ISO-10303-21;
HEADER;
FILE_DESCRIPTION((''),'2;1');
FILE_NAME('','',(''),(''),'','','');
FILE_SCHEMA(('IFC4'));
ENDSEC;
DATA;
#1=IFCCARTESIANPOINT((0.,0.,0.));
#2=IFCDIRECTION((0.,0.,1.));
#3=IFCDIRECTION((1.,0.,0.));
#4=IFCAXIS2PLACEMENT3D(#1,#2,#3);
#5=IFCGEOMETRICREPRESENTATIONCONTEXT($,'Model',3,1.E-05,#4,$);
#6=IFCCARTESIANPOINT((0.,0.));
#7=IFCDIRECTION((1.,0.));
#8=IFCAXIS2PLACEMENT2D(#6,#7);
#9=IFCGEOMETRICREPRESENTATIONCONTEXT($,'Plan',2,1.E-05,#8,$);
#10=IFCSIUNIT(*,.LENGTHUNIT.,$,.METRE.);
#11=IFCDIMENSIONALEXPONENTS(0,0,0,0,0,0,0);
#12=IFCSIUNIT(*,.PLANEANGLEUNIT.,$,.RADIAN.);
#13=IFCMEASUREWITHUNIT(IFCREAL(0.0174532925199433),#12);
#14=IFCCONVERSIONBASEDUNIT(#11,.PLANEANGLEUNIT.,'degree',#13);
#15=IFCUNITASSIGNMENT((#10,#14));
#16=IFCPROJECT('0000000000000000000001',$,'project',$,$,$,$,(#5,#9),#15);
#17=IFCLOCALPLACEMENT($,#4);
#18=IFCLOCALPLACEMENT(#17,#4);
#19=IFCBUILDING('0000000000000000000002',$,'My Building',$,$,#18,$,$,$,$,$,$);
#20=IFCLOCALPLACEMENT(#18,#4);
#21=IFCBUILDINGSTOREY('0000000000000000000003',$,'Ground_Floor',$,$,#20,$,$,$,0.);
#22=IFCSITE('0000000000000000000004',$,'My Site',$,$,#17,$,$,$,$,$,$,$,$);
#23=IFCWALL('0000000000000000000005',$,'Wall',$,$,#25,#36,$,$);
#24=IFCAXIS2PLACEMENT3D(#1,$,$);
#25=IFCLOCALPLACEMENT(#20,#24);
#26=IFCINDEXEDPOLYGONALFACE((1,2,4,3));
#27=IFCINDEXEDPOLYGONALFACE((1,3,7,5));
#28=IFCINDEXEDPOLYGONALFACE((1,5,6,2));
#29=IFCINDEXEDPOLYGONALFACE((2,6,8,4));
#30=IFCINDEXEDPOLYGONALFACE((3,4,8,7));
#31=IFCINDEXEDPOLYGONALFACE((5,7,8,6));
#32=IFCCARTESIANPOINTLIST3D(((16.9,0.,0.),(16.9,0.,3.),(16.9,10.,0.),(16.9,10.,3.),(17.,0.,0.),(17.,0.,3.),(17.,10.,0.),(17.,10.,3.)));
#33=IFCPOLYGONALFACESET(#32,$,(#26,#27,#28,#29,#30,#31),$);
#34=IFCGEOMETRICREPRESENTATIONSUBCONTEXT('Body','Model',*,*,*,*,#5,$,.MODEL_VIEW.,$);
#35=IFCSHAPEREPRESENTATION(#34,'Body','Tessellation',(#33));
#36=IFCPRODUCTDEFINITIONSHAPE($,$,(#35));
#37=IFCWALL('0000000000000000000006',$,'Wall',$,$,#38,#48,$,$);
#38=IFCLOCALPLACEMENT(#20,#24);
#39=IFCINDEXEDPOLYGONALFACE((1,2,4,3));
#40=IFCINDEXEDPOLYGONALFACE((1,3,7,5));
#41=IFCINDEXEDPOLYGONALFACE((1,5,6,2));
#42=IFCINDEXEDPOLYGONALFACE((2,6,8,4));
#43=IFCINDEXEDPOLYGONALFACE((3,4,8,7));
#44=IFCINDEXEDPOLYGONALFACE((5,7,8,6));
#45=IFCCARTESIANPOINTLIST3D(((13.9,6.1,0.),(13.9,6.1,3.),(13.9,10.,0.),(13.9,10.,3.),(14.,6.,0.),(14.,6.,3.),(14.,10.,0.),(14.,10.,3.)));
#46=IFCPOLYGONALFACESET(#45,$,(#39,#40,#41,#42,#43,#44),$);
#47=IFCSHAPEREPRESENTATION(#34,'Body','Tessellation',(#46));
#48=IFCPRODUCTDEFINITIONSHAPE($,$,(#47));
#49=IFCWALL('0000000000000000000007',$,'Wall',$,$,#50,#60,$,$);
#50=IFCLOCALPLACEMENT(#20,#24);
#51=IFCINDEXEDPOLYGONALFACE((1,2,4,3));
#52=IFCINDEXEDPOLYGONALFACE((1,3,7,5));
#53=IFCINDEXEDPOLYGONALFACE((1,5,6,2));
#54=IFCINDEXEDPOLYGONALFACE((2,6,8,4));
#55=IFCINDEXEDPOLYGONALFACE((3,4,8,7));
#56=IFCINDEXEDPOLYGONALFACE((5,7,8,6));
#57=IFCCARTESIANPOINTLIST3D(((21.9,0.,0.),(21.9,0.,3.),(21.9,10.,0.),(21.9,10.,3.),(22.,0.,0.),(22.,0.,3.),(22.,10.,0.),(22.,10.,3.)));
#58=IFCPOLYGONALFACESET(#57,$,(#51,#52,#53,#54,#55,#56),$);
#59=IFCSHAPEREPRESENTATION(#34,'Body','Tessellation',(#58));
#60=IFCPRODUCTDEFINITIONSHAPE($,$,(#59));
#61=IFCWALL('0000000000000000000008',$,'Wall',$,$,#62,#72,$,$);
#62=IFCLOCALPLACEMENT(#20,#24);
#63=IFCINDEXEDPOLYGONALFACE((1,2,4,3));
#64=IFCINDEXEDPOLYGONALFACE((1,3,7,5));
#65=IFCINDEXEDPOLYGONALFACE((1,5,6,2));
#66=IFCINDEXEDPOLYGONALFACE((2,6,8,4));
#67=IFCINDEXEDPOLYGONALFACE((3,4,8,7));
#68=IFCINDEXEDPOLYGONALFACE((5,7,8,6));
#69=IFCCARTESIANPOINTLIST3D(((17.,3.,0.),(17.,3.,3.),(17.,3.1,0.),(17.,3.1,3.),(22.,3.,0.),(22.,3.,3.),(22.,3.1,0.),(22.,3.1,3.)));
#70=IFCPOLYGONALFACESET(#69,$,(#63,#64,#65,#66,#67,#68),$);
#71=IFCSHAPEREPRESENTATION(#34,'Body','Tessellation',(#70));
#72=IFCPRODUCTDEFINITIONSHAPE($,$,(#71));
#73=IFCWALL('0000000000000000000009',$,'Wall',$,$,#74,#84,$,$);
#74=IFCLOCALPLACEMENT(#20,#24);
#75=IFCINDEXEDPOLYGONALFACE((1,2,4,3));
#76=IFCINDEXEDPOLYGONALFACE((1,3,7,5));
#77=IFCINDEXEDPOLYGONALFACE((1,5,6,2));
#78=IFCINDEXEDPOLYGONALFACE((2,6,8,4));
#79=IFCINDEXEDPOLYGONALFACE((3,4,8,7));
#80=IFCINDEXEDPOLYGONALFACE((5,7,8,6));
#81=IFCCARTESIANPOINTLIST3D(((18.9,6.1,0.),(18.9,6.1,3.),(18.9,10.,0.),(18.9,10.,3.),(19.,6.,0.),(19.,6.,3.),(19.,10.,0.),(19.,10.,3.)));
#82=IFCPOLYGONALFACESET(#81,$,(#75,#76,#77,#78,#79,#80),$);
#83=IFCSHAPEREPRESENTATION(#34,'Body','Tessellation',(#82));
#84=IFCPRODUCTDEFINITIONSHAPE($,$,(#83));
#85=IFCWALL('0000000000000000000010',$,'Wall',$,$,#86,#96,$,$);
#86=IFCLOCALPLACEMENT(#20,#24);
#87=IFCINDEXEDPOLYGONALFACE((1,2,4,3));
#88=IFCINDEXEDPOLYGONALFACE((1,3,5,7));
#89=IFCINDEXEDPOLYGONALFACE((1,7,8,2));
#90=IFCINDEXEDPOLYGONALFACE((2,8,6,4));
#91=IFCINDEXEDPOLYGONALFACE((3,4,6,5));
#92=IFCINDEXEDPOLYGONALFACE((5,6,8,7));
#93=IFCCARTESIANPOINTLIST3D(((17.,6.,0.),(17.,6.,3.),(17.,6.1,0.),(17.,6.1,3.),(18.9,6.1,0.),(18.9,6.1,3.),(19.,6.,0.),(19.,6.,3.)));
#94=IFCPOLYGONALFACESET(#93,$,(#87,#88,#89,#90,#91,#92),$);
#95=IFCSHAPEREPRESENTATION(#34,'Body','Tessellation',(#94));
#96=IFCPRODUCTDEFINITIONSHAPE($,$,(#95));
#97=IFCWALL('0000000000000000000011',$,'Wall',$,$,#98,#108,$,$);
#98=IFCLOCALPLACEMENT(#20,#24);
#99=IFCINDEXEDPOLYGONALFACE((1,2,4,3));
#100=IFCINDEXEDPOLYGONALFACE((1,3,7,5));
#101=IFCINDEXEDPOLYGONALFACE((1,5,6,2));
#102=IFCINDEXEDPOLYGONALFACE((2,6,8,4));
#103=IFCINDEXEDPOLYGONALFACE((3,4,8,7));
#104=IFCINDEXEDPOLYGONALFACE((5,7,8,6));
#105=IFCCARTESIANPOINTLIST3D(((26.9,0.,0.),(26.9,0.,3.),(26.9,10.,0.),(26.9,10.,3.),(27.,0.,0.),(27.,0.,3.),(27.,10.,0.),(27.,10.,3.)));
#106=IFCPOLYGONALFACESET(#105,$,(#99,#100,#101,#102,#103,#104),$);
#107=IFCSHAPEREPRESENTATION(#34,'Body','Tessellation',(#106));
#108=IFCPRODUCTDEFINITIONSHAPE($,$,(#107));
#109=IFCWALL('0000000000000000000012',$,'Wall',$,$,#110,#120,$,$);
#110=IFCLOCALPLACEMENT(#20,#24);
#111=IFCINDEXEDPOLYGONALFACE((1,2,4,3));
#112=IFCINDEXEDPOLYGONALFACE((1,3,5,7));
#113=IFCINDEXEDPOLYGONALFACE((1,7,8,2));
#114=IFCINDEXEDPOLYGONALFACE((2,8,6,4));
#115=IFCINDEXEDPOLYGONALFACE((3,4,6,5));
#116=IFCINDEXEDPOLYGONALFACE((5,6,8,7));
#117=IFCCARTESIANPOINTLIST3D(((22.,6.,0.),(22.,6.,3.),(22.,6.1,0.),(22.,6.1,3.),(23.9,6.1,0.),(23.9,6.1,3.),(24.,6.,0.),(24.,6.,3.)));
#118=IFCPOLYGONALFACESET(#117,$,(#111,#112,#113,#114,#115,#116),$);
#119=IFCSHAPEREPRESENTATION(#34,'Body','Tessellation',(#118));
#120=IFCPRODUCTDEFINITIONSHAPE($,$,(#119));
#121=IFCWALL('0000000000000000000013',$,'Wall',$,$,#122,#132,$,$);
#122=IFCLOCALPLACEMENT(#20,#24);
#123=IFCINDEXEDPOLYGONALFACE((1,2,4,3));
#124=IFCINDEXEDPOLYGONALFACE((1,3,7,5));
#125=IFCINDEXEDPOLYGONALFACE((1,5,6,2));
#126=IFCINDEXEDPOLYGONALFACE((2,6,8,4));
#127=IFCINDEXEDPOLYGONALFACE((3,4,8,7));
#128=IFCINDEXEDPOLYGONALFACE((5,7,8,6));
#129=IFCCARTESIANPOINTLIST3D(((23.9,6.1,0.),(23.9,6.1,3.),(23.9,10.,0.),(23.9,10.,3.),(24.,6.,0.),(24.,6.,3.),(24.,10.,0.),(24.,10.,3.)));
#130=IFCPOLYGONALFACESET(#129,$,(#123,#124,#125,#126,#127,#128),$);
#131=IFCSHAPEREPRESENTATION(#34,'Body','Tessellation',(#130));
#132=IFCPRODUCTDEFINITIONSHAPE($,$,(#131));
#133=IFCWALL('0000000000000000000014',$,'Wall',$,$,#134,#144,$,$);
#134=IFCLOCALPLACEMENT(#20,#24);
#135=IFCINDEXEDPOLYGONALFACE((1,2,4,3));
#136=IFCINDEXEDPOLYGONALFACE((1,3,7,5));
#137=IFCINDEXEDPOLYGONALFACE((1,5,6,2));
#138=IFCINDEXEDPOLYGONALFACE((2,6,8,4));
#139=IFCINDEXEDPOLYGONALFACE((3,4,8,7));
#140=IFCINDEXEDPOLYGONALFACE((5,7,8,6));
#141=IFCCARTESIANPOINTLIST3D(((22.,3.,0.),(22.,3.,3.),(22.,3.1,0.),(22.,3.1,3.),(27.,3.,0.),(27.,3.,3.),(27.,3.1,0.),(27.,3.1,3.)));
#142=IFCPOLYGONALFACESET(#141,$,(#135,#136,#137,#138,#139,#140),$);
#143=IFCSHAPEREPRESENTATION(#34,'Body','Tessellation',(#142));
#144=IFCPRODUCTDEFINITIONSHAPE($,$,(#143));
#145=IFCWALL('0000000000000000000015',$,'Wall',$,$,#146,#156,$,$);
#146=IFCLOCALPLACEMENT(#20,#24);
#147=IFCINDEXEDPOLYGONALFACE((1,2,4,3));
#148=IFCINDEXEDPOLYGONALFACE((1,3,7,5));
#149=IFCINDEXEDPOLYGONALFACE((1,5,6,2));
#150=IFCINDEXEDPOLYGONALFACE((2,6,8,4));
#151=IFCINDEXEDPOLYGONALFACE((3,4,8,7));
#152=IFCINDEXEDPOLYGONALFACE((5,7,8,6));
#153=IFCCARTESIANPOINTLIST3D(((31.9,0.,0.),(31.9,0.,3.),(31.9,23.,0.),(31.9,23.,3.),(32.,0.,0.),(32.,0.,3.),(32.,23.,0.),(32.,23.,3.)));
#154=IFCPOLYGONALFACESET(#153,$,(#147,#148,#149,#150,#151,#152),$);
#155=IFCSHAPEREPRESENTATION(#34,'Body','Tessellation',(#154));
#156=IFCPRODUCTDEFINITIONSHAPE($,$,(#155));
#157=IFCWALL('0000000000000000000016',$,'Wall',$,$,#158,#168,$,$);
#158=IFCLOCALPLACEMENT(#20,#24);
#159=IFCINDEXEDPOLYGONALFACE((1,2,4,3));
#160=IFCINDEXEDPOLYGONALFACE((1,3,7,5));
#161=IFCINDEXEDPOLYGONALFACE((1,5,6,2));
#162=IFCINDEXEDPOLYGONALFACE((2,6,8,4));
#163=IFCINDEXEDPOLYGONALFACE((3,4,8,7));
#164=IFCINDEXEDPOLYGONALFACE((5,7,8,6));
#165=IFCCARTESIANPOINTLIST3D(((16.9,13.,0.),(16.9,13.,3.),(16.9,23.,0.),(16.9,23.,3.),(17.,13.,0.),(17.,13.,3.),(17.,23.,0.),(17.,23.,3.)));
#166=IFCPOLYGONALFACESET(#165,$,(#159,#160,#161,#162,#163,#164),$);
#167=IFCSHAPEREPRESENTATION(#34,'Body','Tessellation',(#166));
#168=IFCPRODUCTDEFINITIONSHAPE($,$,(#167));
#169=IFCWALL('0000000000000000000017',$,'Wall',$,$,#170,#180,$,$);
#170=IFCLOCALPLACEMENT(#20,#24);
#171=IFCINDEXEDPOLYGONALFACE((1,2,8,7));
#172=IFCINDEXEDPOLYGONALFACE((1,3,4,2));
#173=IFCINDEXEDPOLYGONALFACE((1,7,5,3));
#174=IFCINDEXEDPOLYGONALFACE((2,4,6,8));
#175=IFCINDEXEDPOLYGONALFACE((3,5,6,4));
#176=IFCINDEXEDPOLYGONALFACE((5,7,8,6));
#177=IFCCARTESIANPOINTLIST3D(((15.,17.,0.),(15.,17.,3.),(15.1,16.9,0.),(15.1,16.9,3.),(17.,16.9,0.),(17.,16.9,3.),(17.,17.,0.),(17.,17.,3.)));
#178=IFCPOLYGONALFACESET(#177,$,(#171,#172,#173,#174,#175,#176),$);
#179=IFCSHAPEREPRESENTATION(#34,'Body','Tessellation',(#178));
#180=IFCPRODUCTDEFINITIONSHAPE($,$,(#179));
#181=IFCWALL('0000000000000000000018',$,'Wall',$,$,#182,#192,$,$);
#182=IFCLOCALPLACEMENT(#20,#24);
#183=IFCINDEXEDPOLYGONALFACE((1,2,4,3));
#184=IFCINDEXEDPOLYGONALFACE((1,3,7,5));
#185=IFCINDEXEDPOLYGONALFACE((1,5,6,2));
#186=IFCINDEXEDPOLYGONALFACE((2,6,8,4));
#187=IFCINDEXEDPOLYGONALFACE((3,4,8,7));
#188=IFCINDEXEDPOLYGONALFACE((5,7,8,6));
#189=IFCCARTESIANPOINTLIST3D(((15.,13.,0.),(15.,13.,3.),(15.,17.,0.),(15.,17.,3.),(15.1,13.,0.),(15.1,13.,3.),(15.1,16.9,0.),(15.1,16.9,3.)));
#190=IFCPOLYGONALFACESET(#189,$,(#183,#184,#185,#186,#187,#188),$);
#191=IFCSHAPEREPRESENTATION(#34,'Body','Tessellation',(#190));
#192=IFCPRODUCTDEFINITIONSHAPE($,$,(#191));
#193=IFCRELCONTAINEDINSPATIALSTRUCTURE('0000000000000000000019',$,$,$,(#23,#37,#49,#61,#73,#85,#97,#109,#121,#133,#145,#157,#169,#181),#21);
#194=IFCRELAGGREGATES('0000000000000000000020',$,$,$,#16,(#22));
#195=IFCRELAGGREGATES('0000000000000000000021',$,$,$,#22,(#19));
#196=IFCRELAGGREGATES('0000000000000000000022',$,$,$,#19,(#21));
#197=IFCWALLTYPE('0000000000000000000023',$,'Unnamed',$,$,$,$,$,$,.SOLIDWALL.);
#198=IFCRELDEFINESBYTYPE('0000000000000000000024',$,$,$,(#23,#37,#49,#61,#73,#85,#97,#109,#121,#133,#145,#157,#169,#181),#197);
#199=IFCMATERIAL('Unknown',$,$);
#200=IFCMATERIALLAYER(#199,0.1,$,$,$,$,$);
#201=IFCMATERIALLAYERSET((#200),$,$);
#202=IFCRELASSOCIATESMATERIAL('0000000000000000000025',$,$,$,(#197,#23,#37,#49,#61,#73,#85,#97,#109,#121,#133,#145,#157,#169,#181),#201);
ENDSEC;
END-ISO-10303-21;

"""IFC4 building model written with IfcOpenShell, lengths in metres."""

from ifc_helpers import new_model, entity, si_unit, converted_unit, frame, origin_with_axes, origin_2d_with_axis, place, context, subcontext, project, spatial, line, indexed_curve, outline, extrude, material, layer, layer_set, layer_usage, type_object, element, save


model = new_model("IFC4")

# Units and contexts
model_context = context("Model", 3, precision=1e-05, world=origin_with_axes())
plan_context = context("Plan", 2, precision=1e-05, world=origin_2d_with_axis())
body_context = subcontext(model_context, "Body", "Model", "MODEL_VIEW")
ifc_project = project(units=[si_unit("LENGTHUNIT", "METRE"), converted_unit("PLANEANGLEUNIT", "degree", entity("IfcReal", 0.0174532925199433), si_unit("PLANEANGLEUNIT", "RADIAN"), dimensions=[0, 0, 0, 0, 0, 0, 0])], contexts=[model_context, plan_context])

# Site, building, storey
site_placement = place(None, origin_with_axes())
site = spatial("IfcSite", under=ifc_project, at=site_placement, Name="My Site")
building_placement = place(site_placement, origin_with_axes())
building = spatial("IfcBuilding", under=site, at=building_placement, Name="My Building")
storey_placement = place(building_placement, origin_with_axes())
storey = spatial("IfcBuildingStorey", under=building, at=storey_placement, Name="Ground_Floor", Elevation=0.0)

# Walls
ifc_material = material(Name="Unknown")
ifc_layer = layer(ifc_material, 0.1)
ifc_layer_set = layer_set([ifc_layer])
ifc_layer_usage_1 = layer_usage(ifc_layer_set, "AXIS2", "POSITIVE", 0.0)
wall_type = type_object("IfcWallType", Name="Unnamed", PredefinedType="SOLIDWALL", material=ifc_layer_set)
wall_1_placement = place(storey_placement, frame((17.0, 0.0, 0.0), z_axis=(0.0, 0.0, 1.0), x_axis=(0.0, 1.0, 0.0)))
element("IfcWall", 1, at=wall_1_placement, inside=storey, type_object=wall_type, material=ifc_layer_usage_1, Name="Wall", context=body_context, shape_type="SweptSolid", body=[
    extrude(outline(indexed_curve([(0.0, 0.0), (0.0, 0.1), (10.0, 0.1), (10.0, 0.0)], segments=[line(1, 2, 3, 4, 1)])), origin_with_axes(), (0.0, 0.0, 1.0), 3.0),
])
ifc_layer_usage_2 = layer_usage(ifc_layer_set, "AXIS2", "POSITIVE", 0.0)
wall_2_placement = place(storey_placement, frame((14.0, 6.0, 0.0), z_axis=(0.0, 0.0, 1.0), x_axis=(0.0, 1.0, 0.0)))
element("IfcWall", 2, at=wall_2_placement, inside=storey, type_object=wall_type, material=ifc_layer_usage_2, Name="Wall", context=body_context, shape_type="SweptSolid", body=[
    extrude(outline(indexed_curve([(0.0, 0.0), (0.1, 0.1), (4.0, 0.1), (4.0, 0.0)], segments=[line(1, 2, 3, 4, 1)])), origin_with_axes(), (0.0, 0.0, 1.0), 3.0),
])
ifc_layer_usage_3 = layer_usage(ifc_layer_set, "AXIS2", "POSITIVE", 0.0)
wall_3_placement = place(storey_placement, frame((22.0, 0.0, 0.0), z_axis=(0.0, 0.0, 1.0), x_axis=(0.0, 1.0, 0.0)))
element("IfcWall", 3, at=wall_3_placement, inside=storey, type_object=wall_type, material=ifc_layer_usage_3, Name="Wall", context=body_context, shape_type="SweptSolid", body=[
    extrude(outline(indexed_curve([(0.0, 0.0), (0.0, 0.1), (10.0, 0.1), (10.0, 0.0)], segments=[line(1, 2, 3, 4, 1)])), origin_with_axes(), (0.0, 0.0, 1.0), 3.0),
])
ifc_layer_usage_4 = layer_usage(ifc_layer_set, "AXIS2", "POSITIVE", 0.0)
wall_4_placement = place(storey_placement, frame((17.0, 3.0, 0.0), z_axis=(0.0, 0.0, 1.0), x_axis=(1.0, 0.0, 0.0)))
element("IfcWall", 4, at=wall_4_placement, inside=storey, type_object=wall_type, material=ifc_layer_usage_4, Name="Wall", context=body_context, shape_type="SweptSolid", body=[
    extrude(outline(indexed_curve([(0.0, 0.0), (0.0, 0.1), (5.0, 0.1), (5.0, 0.0)], segments=[line(1, 2, 3, 4, 1)])), origin_with_axes(), (0.0, 0.0, 1.0), 3.0),
])
ifc_layer_usage_5 = layer_usage(ifc_layer_set, "AXIS2", "POSITIVE", 0.0)
wall_5_placement = place(storey_placement, frame((19.0, 6.0, 0.0), z_axis=(0.0, 0.0, 1.0), x_axis=(0.0, 1.0, 0.0)))
element("IfcWall", 5, at=wall_5_placement, inside=storey, type_object=wall_type, material=ifc_layer_usage_5, Name="Wall", context=body_context, shape_type="SweptSolid", body=[
    extrude(outline(indexed_curve([(0.0, 0.0), (0.1, 0.1), (4.0, 0.1), (4.0, 0.0)], segments=[line(1, 2, 3, 4, 1)])), origin_with_axes(), (0.0, 0.0, 1.0), 3.0),
])
ifc_layer_usage_6 = layer_usage(ifc_layer_set, "AXIS2", "POSITIVE", 0.0)
wall_6_placement = place(storey_placement, frame((17.0, 6.0, 0.0), z_axis=(0.0, 0.0, 1.0), x_axis=(1.0, 0.0, 0.0)))
element("IfcWall", 6, at=wall_6_placement, inside=storey, type_object=wall_type, material=ifc_layer_usage_6, Name="Wall", context=body_context, shape_type="SweptSolid", body=[
    extrude(outline(indexed_curve([(0.0, 0.0), (0.0, 0.1), (1.9, 0.1), (2.0, 0.0)], segments=[line(1, 2, 3, 4, 1)])), origin_with_axes(), (0.0, 0.0, 1.0), 3.0),
])
ifc_layer_usage_7 = layer_usage(ifc_layer_set, "AXIS2", "POSITIVE", 0.0)
wall_7_placement = place(storey_placement, frame((27.0, 0.0, 0.0), z_axis=(0.0, 0.0, 1.0), x_axis=(0.0, 1.0, 0.0)))
element("IfcWall", 7, at=wall_7_placement, inside=storey, type_object=wall_type, material=ifc_layer_usage_7, Name="Wall", context=body_context, shape_type="SweptSolid", body=[
    extrude(outline(indexed_curve([(0.0, 0.0), (0.0, 0.1), (10.0, 0.1), (10.0, 0.0)], segments=[line(1, 2, 3, 4, 1)])), origin_with_axes(), (0.0, 0.0, 1.0), 3.0),
])
ifc_layer_usage_8 = layer_usage(ifc_layer_set, "AXIS2", "POSITIVE", 0.0)
wall_8_placement = place(storey_placement, frame((22.0, 6.0, 0.0), z_axis=(0.0, 0.0, 1.0), x_axis=(1.0, 0.0, 0.0)))
element("IfcWall", 8, at=wall_8_placement, inside=storey, type_object=wall_type, material=ifc_layer_usage_8, Name="Wall", context=body_context, shape_type="SweptSolid", body=[
    extrude(outline(indexed_curve([(0.0, 0.0), (0.0, 0.1), (1.9, 0.1), (2.0, 0.0)], segments=[line(1, 2, 3, 4, 1)])), origin_with_axes(), (0.0, 0.0, 1.0), 3.0),
])
ifc_layer_usage_9 = layer_usage(ifc_layer_set, "AXIS2", "POSITIVE", 0.0)
wall_9_placement = place(storey_placement, frame((24.0, 6.0, 0.0), z_axis=(0.0, 0.0, 1.0), x_axis=(0.0, 1.0, 0.0)))
element("IfcWall", 9, at=wall_9_placement, inside=storey, type_object=wall_type, material=ifc_layer_usage_9, Name="Wall", context=body_context, shape_type="SweptSolid", body=[
    extrude(outline(indexed_curve([(0.0, 0.0), (0.1, 0.1), (4.0, 0.1), (4.0, 0.0)], segments=[line(1, 2, 3, 4, 1)])), origin_with_axes(), (0.0, 0.0, 1.0), 3.0),
])
ifc_layer_usage_10 = layer_usage(ifc_layer_set, "AXIS2", "POSITIVE", 0.0)
wall_10_placement = place(storey_placement, frame((22.0, 3.0, 0.0), z_axis=(0.0, 0.0, 1.0), x_axis=(1.0, 0.0, 0.0)))
element("IfcWall", 10, at=wall_10_placement, inside=storey, type_object=wall_type, material=ifc_layer_usage_10, Name="Wall", context=body_context, shape_type="SweptSolid", body=[
    extrude(outline(indexed_curve([(0.0, 0.0), (0.0, 0.1), (5.0, 0.1), (5.0, 0.0)], segments=[line(1, 2, 3, 4, 1)])), origin_with_axes(), (0.0, 0.0, 1.0), 3.0),
])
ifc_layer_usage_11 = layer_usage(ifc_layer_set, "AXIS2", "POSITIVE", 0.0)
wall_11_placement = place(storey_placement, frame((32.0, 0.0, 0.0), z_axis=(0.0, 0.0, 1.0), x_axis=(0.0, 1.0, 0.0)))
element("IfcWall", 11, at=wall_11_placement, inside=storey, type_object=wall_type, material=ifc_layer_usage_11, Name="Wall", context=body_context, shape_type="SweptSolid", body=[
    extrude(outline(indexed_curve([(0.0, 0.0), (0.0, 0.1), (23.0, 0.1), (23.0, 0.0)], segments=[line(1, 2, 3, 4, 1)])), origin_with_axes(), (0.0, 0.0, 1.0), 3.0),
])
ifc_layer_usage_12 = layer_usage(ifc_layer_set, "AXIS2", "POSITIVE", 0.0)
wall_12_placement = place(storey_placement, frame((17.0, 13.0, 0.0), z_axis=(0.0, 0.0, 1.0), x_axis=(0.0, 1.0, 0.0)))
element("IfcWall", 12, at=wall_12_placement, inside=storey, type_object=wall_type, material=ifc_layer_usage_12, Name="Wall", context=body_context, shape_type="SweptSolid", body=[
    extrude(outline(indexed_curve([(0.0, 0.0), (0.0, 0.1), (10.0, 0.1), (10.0, 0.0)], segments=[line(1, 2, 3, 4, 1)])), origin_with_axes(), (0.0, 0.0, 1.0), 3.0),
])
ifc_layer_usage_13 = layer_usage(ifc_layer_set, "AXIS2", "POSITIVE", 0.0)
wall_13_placement = place(storey_placement, frame((17.0, 17.0, 0.0), z_axis=(0.0, 0.0, 1.0), x_axis=(-1.0, 0.0, 0.0)))
element("IfcWall", 13, at=wall_13_placement, inside=storey, type_object=wall_type, material=ifc_layer_usage_13, Name="Wall", context=body_context, shape_type="SweptSolid", body=[
    extrude(outline(indexed_curve([(0.0, 0.0), (0.0, 0.1), (1.9, 0.1), (2.0, 0.0)], segments=[line(1, 2, 3, 4, 1)])), origin_with_axes(), (0.0, 0.0, 1.0), 3.0),
])
ifc_layer_usage_14 = layer_usage(ifc_layer_set, "AXIS2", "POSITIVE", 0.0)
wall_14_placement = place(storey_placement, frame((15.0, 17.0, 0.0), z_axis=(0.0, 0.0, 1.0), x_axis=(0.0, -1.0, 0.0)))
element("IfcWall", 14, at=wall_14_placement, inside=storey, type_object=wall_type, material=ifc_layer_usage_14, Name="Wall", context=body_context, shape_type="SweptSolid", body=[
    extrude(outline(indexed_curve([(0.0, 0.0), (0.1, 0.1), (4.0, 0.1), (4.0, 0.0)], segments=[line(1, 2, 3, 4, 1)])), origin_with_axes(), (0.0, 0.0, 1.0), 3.0),
])

save(model, "model.ifc")
